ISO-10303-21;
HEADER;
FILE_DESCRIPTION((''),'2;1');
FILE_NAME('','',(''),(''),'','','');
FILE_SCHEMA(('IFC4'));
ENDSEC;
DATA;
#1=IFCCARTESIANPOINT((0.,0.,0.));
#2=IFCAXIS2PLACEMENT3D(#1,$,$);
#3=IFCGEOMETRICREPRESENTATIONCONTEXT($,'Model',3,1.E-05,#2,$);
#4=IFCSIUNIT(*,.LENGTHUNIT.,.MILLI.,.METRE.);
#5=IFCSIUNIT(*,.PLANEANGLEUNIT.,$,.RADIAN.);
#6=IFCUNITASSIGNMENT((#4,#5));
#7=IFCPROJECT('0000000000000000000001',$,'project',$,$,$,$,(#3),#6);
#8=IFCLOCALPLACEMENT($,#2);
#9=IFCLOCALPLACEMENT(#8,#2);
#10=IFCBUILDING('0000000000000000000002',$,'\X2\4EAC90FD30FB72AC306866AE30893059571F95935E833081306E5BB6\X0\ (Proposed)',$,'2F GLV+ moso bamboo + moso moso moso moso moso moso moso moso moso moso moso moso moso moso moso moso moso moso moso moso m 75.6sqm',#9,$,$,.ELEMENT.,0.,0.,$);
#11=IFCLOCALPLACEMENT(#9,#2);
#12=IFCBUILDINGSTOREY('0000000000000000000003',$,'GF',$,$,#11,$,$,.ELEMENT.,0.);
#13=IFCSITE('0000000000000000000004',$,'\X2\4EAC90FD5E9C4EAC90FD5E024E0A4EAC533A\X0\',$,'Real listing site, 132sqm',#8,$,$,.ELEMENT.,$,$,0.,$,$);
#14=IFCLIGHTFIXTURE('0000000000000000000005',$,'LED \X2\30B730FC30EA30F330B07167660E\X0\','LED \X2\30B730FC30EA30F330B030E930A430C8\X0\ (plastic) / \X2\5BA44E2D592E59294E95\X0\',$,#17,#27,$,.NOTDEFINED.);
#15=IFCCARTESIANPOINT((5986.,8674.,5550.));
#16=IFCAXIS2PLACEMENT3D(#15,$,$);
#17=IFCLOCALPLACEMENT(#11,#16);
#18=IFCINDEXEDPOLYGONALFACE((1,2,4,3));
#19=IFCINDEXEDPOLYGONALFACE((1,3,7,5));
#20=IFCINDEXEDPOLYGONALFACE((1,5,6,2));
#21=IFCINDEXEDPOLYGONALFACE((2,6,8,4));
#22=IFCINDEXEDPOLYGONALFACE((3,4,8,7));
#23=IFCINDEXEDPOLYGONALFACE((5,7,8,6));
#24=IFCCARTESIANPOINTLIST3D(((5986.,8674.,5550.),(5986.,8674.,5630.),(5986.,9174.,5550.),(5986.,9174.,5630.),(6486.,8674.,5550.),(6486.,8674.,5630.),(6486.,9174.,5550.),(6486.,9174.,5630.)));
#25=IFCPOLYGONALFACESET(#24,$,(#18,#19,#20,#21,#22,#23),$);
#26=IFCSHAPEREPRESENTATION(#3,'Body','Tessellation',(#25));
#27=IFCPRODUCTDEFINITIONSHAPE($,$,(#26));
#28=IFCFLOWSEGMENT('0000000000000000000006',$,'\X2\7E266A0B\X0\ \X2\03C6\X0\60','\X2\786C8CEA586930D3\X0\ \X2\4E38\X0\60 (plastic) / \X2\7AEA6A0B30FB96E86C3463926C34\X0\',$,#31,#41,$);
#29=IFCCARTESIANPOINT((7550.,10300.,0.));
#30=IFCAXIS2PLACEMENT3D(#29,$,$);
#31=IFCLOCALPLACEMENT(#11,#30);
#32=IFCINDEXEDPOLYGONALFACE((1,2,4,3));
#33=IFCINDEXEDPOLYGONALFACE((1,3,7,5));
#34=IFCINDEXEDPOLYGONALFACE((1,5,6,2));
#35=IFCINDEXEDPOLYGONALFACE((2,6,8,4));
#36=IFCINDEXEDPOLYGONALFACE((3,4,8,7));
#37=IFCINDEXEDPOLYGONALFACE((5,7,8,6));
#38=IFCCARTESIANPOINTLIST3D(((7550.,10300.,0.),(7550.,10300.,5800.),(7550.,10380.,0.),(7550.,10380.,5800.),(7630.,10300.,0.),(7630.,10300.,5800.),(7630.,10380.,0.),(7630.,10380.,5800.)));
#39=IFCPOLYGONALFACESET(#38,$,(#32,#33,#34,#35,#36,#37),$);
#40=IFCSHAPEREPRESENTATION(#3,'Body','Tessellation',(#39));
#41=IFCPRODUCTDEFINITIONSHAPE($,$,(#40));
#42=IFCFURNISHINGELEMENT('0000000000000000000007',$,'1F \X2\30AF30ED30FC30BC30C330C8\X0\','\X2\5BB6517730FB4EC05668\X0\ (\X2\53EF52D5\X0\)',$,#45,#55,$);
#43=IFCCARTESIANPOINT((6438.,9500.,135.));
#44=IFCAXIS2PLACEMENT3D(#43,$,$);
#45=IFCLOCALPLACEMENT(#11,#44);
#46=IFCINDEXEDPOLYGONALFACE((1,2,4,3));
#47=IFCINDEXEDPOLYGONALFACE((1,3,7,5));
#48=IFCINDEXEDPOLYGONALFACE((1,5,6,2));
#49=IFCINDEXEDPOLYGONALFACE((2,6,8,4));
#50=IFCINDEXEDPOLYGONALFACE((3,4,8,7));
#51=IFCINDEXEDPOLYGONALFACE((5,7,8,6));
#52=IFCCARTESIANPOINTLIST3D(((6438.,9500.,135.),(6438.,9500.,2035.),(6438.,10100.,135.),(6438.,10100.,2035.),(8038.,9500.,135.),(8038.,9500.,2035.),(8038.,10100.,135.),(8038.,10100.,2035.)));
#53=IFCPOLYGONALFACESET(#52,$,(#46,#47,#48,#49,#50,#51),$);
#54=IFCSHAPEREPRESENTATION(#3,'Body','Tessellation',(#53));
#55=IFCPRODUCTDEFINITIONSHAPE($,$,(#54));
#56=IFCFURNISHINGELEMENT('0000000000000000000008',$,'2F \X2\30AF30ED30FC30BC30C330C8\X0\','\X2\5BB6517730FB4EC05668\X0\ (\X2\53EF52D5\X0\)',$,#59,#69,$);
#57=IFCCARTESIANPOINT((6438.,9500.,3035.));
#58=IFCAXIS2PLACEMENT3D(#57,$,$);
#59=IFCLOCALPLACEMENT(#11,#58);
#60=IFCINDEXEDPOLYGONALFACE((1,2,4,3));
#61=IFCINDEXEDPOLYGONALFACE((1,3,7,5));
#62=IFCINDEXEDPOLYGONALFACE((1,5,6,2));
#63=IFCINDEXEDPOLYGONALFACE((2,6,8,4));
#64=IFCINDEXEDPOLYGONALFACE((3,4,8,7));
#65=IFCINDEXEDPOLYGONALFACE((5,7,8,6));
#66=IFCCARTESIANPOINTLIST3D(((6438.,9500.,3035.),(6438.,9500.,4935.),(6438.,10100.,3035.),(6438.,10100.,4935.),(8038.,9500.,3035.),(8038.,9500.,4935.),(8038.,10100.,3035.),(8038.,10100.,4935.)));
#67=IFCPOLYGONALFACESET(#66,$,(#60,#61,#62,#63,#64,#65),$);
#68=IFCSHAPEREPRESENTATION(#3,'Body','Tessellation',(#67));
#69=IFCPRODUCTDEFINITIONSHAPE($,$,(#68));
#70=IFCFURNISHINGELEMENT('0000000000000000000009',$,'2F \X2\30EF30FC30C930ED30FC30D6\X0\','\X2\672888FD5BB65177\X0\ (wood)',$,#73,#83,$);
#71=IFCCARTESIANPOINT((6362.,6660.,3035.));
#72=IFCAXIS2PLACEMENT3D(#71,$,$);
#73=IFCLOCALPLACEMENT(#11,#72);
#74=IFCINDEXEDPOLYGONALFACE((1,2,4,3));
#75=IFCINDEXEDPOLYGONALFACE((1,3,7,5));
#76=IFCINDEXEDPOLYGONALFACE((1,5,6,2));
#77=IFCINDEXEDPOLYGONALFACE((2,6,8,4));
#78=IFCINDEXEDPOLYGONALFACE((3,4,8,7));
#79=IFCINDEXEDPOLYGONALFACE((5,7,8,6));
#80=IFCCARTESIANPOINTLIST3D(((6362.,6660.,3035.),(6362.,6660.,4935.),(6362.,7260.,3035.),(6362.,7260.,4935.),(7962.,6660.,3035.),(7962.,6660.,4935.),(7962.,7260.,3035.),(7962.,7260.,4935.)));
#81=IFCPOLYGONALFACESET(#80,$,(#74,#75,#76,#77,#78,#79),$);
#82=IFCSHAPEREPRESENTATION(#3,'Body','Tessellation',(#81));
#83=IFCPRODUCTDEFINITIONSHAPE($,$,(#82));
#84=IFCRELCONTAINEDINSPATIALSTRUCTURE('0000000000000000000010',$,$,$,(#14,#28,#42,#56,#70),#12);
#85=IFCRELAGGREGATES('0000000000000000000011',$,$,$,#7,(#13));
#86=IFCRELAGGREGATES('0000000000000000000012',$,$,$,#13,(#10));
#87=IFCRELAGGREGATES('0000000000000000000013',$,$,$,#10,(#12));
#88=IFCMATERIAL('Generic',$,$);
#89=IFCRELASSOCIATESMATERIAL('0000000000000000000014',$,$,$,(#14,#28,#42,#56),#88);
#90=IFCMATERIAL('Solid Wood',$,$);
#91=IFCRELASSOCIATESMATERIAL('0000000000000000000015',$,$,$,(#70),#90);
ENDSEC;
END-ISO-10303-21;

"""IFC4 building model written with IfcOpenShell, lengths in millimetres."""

from ifc_helpers import new_model, si_unit, frame, frame_2d, origin, place, context, project, spatial, rectangle, extrude, material, element, save


model = new_model("IFC4")

# Units and contexts
model_context = context("Model", 3, precision=1e-05, world=origin())
ifc_project = project(units=[si_unit("LENGTHUNIT", "METRE", prefix="MILLI"), si_unit("PLANEANGLEUNIT", "RADIAN")], contexts=[model_context])

# Site, building, storey
site_placement = place(None, origin())
site = spatial("IfcSite", under=ifc_project, at=site_placement, Name="京都府京都市上京区", ObjectType="Real listing site, 132sqm", CompositionType="ELEMENT", RefElevation=0.0)
building_placement = place(site_placement, origin())
building = spatial("IfcBuilding", under=site, at=building_placement, Name="京都・犬と暮らす土間広めの家 (Proposed)", ObjectType="2F GLV+ moso bamboo + moso moso moso moso moso moso moso moso moso moso moso moso moso moso moso moso moso moso moso moso m 75.6sqm", CompositionType="ELEMENT", ElevationOfRefHeight=0.0, ElevationOfTerrain=0.0)
storey_placement = place(building_placement, origin())
storey = spatial("IfcBuildingStorey", under=building, at=storey_placement, Name="GF", CompositionType="ELEMENT", Elevation=0.0)

# Shared definitions
ifc_material_1 = material(Name="Solid Wood")

# Shared definitions
ifc_material_2 = material(Name="Generic")

# Light fixture
light_fixture_1_placement = place(storey_placement, frame((5986.0, 8674.0, 5550.0)))
element("IfcLightFixture", 1, at=light_fixture_1_placement, inside=storey, material=ifc_material_2, Name="LED シーリング照明", Description="LED シーリングライト (plastic) / 室中央天井", PredefinedType="NOTDEFINED", context=model_context, shape_type="SweptSolid", body=[
    extrude(rectangle(XDim=500.0, YDim=500.0, at=frame_2d((250.0, 250.0))), frame((5986.0, 8674.0, 5550.0)), (0.0, 0.0, 1.0), 80.0),
])

# Flow segment
flow_segment_placement = place(storey_placement, frame((7550.0, 10300.0, 0.0)))
element("IfcFlowSegment", 2, at=flow_segment_placement, inside=storey, material=ifc_material_2, Name="縦樋 φ60", Description="硬質塩ビ 丸60 (plastic) / 竪樋・雨水排水", context=model_context, shape_type="SweptSolid", body=[
    extrude(rectangle(XDim=80.0, YDim=80.0, at=frame_2d((40.0, 40.0))), frame((7550.0, 10300.0, 0.0)), (0.0, 0.0, 1.0), 5800.0),
])

# Furnishing elements
furnishing_1_placement = place(storey_placement, frame((6438.0, 9500.0, 135.0)))
element("IfcFurnishingElement", 3, at=furnishing_1_placement, inside=storey, material=ifc_material_2, Name="1F クローゼット", Description="家具・什器 (可動)", context=model_context, shape_type="SweptSolid", body=[
    extrude(rectangle(XDim=1600.0, YDim=600.0, at=frame_2d((800.0, 300.0))), frame((6438.0, 9500.0, 135.0)), (0.0, 0.0, 1.0), 1900.0),
])
furnishing_2_placement = place(storey_placement, frame((6438.0, 9500.0, 3035.0)))
element("IfcFurnishingElement", 4, at=furnishing_2_placement, inside=storey, material=ifc_material_2, Name="2F クローゼット", Description="家具・什器 (可動)", context=model_context, shape_type="SweptSolid", body=[
    extrude(rectangle(XDim=1600.0, YDim=600.0, at=frame_2d((800.0, 300.0))), frame((6438.0, 9500.0, 3035.0)), (0.0, 0.0, 1.0), 1900.0),
])
furnishing_3_placement = place(storey_placement, frame((6362.0, 6660.0, 3035.0)))
element("IfcFurnishingElement", 5, at=furnishing_3_placement, inside=storey, material=ifc_material_1, Name="2F ワードローブ", Description="木製家具 (wood)", context=model_context, shape_type="SweptSolid", body=[
    extrude(rectangle(XDim=1600.0, YDim=600.0, at=frame_2d((800.0, 300.0))), frame((6362.0, 6660.0, 3035.0)), (0.0, 0.0, 1.0), 1900.0),
])

save(model, "model.ifc")
